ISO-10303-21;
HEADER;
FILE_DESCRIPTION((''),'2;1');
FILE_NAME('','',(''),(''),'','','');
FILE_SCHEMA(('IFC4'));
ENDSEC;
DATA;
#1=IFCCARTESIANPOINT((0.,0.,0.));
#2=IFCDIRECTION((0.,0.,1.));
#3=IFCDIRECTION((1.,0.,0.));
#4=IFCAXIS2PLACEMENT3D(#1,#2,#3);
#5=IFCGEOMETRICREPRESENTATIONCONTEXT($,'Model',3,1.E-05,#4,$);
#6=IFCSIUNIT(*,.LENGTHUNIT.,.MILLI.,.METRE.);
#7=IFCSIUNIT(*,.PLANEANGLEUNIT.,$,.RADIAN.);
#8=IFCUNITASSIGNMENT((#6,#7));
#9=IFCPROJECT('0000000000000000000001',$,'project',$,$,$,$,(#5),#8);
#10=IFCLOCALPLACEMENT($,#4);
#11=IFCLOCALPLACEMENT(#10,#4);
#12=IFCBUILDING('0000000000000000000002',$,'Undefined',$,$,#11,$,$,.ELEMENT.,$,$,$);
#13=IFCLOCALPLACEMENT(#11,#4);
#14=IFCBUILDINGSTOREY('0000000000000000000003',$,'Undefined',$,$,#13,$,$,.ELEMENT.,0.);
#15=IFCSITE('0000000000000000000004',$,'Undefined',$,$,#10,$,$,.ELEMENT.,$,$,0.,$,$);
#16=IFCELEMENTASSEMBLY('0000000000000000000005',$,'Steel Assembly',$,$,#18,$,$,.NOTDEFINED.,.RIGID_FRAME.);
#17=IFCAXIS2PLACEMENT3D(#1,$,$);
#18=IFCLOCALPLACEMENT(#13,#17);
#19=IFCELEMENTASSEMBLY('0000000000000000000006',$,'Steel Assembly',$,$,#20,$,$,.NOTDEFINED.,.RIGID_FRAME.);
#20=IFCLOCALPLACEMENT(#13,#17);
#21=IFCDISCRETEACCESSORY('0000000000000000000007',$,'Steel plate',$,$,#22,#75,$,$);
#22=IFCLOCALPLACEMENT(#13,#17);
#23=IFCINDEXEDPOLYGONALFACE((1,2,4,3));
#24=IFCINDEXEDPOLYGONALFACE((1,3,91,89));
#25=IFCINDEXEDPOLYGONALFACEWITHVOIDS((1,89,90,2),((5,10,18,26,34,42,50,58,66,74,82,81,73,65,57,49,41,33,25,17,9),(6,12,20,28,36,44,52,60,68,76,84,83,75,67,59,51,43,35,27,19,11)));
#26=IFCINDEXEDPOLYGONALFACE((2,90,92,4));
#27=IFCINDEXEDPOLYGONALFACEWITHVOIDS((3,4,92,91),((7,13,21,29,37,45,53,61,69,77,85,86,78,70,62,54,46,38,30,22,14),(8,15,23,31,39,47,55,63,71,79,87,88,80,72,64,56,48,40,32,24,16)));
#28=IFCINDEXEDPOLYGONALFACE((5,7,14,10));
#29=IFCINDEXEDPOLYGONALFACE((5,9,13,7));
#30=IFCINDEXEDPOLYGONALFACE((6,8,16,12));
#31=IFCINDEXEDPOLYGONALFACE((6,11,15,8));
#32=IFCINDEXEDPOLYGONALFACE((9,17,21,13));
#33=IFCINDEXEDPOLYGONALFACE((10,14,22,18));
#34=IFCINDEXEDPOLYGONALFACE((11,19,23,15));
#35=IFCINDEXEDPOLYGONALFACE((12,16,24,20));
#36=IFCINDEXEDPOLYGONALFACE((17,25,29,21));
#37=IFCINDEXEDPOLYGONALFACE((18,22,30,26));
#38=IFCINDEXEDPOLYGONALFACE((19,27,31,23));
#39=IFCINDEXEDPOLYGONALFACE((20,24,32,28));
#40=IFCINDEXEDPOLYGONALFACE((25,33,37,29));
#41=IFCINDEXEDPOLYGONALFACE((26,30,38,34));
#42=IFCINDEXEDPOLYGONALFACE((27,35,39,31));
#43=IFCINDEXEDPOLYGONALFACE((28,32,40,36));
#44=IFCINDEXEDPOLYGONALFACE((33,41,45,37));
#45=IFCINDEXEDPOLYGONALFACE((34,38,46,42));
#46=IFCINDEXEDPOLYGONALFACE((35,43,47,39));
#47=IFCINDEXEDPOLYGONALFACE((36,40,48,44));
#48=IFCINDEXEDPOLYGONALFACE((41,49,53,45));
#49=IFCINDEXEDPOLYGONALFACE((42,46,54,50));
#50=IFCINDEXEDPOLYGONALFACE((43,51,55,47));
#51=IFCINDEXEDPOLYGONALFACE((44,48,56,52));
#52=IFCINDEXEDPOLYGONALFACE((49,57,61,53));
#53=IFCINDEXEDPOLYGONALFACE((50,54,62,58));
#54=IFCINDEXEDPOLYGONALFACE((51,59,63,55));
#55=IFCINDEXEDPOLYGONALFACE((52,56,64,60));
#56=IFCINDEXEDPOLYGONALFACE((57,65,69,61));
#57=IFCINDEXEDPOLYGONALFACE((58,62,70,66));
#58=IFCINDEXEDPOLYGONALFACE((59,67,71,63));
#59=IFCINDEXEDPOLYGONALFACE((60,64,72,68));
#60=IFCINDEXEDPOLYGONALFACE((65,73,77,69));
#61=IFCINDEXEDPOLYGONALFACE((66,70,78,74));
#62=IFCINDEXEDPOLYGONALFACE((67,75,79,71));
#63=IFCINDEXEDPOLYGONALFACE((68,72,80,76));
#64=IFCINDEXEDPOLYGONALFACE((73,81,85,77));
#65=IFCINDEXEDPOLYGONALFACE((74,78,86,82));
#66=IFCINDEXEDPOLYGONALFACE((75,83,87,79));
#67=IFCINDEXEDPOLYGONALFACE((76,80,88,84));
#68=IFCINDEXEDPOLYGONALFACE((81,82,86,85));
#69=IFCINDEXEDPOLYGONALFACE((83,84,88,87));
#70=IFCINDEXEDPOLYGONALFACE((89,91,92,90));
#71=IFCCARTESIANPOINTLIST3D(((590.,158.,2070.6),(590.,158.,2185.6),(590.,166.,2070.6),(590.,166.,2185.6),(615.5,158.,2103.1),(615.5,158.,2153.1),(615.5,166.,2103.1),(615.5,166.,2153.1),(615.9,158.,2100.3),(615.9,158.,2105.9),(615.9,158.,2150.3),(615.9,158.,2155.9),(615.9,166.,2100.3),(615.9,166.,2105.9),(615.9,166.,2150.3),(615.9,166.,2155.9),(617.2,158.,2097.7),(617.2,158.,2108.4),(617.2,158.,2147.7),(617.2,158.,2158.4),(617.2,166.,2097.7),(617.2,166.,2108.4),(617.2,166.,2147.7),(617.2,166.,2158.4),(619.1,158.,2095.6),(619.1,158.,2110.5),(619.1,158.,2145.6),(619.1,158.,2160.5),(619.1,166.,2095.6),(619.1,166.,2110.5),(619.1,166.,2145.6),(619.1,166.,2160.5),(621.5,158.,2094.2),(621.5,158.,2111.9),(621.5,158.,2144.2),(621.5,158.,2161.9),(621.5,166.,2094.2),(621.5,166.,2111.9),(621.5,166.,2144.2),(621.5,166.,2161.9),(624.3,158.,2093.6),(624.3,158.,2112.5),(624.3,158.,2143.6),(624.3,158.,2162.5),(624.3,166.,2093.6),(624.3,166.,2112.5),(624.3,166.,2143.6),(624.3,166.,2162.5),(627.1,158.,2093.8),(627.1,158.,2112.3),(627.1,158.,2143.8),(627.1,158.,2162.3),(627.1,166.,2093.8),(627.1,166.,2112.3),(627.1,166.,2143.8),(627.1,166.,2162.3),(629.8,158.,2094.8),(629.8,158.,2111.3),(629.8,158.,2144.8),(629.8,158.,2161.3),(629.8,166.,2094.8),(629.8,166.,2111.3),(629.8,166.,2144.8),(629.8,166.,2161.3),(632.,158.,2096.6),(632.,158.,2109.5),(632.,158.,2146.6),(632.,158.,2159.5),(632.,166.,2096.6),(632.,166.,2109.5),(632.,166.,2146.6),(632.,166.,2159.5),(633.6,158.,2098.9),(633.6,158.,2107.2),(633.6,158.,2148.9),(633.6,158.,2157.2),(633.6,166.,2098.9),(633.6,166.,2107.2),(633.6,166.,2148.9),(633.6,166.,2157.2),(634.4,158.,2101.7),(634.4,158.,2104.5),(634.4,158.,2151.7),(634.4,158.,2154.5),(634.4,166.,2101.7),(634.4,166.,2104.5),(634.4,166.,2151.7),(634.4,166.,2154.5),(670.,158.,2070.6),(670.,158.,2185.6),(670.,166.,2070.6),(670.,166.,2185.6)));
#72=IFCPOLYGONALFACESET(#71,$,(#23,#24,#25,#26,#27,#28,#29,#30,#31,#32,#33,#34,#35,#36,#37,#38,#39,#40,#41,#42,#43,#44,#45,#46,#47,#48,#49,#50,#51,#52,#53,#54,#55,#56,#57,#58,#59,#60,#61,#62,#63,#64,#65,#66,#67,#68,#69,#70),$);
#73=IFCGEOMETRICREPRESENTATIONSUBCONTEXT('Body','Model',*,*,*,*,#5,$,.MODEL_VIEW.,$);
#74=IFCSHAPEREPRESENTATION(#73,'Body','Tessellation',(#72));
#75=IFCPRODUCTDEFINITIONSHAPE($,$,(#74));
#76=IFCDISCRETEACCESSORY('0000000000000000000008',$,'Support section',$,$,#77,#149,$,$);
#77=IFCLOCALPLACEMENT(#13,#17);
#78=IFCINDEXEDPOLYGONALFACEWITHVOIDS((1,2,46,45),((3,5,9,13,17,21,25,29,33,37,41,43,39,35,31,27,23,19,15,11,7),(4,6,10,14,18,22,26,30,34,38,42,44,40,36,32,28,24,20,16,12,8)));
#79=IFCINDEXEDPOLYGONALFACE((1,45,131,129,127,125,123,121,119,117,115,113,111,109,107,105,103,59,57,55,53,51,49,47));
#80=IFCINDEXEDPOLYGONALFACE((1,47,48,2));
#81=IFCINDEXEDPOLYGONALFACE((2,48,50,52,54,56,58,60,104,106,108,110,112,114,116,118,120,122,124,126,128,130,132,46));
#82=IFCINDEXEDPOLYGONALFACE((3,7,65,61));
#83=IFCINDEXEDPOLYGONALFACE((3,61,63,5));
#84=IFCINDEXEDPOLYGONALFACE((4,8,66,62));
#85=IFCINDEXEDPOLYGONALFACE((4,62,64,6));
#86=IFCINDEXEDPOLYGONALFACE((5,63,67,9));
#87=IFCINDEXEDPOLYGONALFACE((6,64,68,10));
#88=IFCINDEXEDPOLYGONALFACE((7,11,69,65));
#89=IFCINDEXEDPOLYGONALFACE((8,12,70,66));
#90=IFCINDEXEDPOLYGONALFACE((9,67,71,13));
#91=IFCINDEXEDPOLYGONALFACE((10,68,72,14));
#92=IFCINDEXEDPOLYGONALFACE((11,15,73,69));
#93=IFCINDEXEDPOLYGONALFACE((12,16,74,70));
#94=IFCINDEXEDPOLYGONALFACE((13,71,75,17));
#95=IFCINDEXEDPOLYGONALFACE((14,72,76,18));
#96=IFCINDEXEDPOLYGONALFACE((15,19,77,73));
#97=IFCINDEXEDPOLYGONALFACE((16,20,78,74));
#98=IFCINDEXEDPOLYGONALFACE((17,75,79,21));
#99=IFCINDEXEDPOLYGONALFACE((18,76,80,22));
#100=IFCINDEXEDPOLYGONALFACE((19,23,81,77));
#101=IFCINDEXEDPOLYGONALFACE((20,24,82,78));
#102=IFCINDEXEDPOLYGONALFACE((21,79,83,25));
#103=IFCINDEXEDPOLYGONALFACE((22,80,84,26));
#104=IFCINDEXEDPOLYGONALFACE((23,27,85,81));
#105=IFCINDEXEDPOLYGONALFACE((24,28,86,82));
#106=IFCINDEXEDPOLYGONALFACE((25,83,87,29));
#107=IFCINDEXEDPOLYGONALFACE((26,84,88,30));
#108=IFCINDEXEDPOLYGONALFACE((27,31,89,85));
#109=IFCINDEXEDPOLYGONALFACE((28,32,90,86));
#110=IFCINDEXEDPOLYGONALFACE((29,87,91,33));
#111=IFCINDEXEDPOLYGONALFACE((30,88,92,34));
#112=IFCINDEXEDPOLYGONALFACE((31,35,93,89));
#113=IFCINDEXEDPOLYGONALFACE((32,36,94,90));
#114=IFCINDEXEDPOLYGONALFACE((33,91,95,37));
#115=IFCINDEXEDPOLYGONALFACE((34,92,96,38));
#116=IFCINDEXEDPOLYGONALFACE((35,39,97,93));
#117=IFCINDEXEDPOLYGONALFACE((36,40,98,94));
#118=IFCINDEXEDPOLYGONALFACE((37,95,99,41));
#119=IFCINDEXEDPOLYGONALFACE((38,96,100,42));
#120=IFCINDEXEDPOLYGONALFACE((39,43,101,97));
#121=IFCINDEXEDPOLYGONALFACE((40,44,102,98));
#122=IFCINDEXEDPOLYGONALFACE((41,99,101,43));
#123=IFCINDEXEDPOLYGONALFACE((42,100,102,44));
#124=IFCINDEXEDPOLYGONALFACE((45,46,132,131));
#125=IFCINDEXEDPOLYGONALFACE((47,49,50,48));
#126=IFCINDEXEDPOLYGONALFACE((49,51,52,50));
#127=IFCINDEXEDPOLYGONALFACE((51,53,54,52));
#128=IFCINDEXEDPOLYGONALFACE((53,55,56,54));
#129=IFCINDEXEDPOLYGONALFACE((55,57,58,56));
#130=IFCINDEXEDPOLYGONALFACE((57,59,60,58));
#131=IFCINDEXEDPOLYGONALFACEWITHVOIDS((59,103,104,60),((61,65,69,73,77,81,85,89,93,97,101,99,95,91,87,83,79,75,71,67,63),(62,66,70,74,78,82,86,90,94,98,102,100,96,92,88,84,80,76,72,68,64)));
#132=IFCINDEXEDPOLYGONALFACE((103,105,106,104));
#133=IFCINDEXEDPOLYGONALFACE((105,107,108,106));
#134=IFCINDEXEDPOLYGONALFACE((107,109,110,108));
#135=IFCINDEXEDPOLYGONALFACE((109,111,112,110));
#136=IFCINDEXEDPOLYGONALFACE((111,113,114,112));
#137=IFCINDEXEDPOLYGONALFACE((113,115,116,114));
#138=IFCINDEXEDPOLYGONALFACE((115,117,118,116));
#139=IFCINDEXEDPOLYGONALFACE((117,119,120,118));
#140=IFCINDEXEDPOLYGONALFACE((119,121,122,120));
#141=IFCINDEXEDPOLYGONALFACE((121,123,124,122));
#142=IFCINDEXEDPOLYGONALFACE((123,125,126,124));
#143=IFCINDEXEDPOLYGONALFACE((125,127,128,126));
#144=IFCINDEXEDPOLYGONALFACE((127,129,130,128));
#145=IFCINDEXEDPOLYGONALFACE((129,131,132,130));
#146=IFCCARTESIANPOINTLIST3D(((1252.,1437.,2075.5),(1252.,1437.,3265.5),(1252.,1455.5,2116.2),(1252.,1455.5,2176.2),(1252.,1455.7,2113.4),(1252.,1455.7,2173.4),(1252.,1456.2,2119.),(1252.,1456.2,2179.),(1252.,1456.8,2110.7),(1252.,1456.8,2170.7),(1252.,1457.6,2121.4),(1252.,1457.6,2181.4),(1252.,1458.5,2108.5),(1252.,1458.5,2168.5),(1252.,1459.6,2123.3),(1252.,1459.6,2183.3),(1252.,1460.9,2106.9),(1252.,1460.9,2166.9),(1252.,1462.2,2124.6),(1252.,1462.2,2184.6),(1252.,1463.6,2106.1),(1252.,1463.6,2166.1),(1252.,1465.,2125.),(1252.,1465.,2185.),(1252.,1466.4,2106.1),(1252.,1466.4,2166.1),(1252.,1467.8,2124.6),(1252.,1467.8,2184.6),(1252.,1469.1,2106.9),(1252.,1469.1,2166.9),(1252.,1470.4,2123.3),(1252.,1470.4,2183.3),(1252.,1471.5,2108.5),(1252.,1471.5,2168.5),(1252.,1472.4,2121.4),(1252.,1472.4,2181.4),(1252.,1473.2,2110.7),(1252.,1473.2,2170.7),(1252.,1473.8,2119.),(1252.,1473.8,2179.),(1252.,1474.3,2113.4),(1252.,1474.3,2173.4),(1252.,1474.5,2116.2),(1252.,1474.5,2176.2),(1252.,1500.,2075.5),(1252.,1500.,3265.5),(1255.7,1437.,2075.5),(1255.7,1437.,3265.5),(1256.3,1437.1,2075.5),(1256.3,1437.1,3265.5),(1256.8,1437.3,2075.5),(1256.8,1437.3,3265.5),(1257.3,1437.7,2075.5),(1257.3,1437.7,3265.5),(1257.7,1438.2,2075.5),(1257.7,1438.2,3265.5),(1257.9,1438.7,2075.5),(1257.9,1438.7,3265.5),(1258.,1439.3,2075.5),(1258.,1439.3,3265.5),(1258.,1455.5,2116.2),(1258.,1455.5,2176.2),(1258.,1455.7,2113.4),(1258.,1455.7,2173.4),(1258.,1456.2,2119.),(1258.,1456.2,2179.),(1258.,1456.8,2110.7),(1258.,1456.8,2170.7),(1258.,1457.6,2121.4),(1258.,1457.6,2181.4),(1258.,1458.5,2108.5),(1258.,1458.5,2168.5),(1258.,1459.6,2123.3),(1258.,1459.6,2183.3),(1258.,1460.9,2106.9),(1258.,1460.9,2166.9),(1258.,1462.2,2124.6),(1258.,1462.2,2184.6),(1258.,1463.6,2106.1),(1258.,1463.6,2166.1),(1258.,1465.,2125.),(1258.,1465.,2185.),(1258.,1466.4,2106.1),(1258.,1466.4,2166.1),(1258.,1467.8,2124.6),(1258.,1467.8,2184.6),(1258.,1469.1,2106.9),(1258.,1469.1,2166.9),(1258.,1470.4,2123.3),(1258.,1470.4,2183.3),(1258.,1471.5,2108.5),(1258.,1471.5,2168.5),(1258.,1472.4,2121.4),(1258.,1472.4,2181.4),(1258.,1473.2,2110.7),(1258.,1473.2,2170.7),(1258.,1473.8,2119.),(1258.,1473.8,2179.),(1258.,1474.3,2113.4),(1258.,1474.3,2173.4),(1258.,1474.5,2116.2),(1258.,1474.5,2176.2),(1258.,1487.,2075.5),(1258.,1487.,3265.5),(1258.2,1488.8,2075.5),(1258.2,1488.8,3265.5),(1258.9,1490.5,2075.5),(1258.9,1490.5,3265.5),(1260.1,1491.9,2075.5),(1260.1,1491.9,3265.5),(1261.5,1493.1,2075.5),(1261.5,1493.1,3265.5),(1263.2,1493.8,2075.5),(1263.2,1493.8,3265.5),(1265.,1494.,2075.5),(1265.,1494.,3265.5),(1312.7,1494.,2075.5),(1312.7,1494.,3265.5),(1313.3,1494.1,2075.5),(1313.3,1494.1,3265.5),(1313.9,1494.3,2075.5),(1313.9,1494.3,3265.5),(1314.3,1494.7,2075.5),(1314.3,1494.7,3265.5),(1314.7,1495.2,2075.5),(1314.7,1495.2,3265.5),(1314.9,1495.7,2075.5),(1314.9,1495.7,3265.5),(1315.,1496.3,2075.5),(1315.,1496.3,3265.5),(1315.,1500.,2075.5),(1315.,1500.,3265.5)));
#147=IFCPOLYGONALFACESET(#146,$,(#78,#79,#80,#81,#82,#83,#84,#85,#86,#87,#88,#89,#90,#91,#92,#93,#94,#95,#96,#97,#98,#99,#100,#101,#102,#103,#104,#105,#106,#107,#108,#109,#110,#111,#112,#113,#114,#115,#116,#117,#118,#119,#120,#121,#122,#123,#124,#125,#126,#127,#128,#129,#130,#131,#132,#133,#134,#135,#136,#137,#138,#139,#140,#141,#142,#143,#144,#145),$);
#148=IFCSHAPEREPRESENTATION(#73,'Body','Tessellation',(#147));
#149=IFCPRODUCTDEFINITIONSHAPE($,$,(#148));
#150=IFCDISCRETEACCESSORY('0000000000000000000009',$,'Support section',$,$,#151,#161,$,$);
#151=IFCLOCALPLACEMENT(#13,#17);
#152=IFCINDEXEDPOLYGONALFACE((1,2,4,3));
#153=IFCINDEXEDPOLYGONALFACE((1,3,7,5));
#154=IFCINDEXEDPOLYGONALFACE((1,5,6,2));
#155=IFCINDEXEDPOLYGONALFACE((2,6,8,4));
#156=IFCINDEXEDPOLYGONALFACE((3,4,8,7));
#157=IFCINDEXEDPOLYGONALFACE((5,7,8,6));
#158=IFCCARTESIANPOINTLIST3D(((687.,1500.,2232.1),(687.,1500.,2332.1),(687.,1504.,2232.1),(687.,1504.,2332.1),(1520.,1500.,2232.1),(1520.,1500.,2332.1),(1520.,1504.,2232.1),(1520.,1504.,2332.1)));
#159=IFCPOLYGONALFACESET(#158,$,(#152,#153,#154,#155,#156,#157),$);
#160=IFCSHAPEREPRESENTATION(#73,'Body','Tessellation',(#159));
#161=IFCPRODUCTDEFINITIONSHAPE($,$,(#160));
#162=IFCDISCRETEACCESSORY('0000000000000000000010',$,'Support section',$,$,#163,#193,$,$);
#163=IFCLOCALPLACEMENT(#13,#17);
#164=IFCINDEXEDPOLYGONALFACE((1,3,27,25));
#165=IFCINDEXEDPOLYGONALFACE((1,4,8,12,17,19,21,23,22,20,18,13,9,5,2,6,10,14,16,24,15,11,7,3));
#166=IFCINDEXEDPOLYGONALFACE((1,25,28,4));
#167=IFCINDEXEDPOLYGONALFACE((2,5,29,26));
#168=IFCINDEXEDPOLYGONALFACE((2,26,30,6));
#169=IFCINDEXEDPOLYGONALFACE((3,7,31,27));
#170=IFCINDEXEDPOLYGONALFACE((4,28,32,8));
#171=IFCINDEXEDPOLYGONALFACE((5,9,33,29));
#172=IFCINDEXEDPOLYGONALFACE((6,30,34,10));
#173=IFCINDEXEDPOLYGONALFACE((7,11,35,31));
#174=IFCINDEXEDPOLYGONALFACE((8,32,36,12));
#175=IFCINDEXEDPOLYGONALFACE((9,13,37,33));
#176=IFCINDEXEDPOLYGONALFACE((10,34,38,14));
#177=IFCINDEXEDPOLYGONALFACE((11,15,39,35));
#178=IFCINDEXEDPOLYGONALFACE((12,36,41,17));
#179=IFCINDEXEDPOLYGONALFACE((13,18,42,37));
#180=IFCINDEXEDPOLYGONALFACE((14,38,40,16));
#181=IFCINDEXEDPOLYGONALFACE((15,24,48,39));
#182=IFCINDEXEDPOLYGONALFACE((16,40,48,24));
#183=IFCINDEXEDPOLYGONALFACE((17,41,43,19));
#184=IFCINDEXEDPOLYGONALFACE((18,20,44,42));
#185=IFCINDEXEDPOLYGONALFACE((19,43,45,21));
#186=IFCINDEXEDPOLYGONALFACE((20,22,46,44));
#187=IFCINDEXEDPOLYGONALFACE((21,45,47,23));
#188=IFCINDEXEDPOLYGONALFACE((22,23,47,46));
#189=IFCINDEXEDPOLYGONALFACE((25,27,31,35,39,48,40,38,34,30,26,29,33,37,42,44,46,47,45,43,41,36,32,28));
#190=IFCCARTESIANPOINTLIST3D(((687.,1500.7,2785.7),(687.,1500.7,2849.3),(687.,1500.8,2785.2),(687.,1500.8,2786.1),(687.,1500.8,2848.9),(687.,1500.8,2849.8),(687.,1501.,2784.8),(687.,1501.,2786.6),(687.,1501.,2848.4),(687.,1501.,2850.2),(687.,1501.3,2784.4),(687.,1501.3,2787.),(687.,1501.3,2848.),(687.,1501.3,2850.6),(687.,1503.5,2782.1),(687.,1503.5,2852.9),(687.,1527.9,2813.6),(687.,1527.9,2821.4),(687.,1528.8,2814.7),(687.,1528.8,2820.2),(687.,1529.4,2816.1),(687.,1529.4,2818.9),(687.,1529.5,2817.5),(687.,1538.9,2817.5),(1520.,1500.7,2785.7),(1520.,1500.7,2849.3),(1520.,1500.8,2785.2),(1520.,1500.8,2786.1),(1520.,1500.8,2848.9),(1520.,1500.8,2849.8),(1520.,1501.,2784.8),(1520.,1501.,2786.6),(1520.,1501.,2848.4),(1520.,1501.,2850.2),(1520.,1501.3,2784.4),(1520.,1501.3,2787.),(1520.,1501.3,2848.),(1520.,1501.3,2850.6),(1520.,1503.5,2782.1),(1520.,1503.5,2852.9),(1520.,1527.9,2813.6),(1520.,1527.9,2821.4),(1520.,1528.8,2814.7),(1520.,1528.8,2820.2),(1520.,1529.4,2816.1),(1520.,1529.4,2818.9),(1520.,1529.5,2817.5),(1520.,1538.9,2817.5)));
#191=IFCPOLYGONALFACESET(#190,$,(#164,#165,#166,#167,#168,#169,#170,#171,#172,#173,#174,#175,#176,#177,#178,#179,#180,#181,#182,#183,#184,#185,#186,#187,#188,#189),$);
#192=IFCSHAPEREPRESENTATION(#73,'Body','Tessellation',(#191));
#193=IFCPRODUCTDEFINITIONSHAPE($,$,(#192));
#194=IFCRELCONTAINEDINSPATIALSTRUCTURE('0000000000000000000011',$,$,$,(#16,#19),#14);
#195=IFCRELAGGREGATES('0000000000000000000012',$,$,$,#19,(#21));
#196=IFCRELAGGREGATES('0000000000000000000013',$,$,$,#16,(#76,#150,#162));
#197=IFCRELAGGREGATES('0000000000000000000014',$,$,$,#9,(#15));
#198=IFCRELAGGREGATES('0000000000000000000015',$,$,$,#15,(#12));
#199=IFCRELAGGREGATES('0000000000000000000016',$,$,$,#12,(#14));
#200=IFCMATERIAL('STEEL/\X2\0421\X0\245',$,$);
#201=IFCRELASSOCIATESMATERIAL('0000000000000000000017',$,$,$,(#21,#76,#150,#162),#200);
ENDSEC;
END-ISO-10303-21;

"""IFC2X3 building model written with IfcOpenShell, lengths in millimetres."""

from ifc_helpers import new_model, si_unit, frame, origin_with_axes, origin_2d_with_axis, place, context, subcontext, project, spatial, polyline, rectangle, circle, l_section, outline, extrude, source, transform, mapped, material, element, aggregate, save


model = new_model("IFC2X3")

# Units and contexts
model_context = context("Model", 3, precision=1e-05, world=origin_with_axes())
body_context = subcontext(model_context, "Body", "Model", "MODEL_VIEW")
ifc_project = project(units=[si_unit("LENGTHUNIT", "METRE", prefix="MILLI"), si_unit("PLANEANGLEUNIT", "RADIAN")], contexts=[model_context])

# Site, building, storey
site_placement = place(None, origin_with_axes())
site = spatial("IfcSite", under=ifc_project, at=site_placement, Name="Undefined", CompositionType="ELEMENT", RefElevation=0.0)
building_placement = place(site_placement, origin_with_axes())
building = spatial("IfcBuilding", under=site, at=building_placement, Name="Undefined", CompositionType="ELEMENT")
storey_placement = place(building_placement, origin_with_axes())
storey = spatial("IfcBuildingStorey", under=building, at=storey_placement, Name="Undefined", CompositionType="ELEMENT", Elevation=0.0)

# Element assembly
assembly_1_placement = place(storey_placement, origin_with_axes())
assembly_1 = element("IfcElementAssembly", 1, at=assembly_1_placement, inside=storey, Name="Steel Assembly", AssemblyPlace="NOTDEFINED", PredefinedType="RIGID_FRAME")
ifc_material_1 = material(Name="STEEL/С245")
shared_shape_1 = source(origin_with_axes(), body_context, "Body", "SweptSolid", [
    extrude(circle(Radius=9.5, at=origin_2d_with_axis()), frame((0.0, -0.1, 0.0), z_axis=(0.0, 1.0, 0.0), x_axis=(1.0, 0.0, 0.0)), (0.0, 0.0, 1.0), 6.2),
])

# Element assembly
assembly_2_placement = place(storey_placement, origin_with_axes())
assembly_2 = element("IfcElementAssembly", 2, at=assembly_2_placement, inside=storey, Name="Steel Assembly", AssemblyPlace="NOTDEFINED", PredefinedType="RIGID_FRAME")

# Discrete accessories, openings
discrete_accessory_1_placement = place(assembly_2_placement, frame((670.0, 162.0, 2185.6), z_axis=(0.0, -1.0, 0.0), x_axis=(-1.0, 0.0, 0.0)))
discrete_accessory_1 = element("IfcDiscreteAccessory", 3, at=discrete_accessory_1_placement, material=ifc_material_1, Name="Steel plate", context=body_context, shape_type="SweptSolid", body=[
    extrude(outline(polyline([(0.0, 0.0), (80.0, 0.0), (80.0, 115.0), (0.0, 115.0), (0.0, 0.0)])), frame((0.0, 0.0, -4.0), z_axis=(0.0, 0.0, 1.0), x_axis=(1.0, 0.0, 0.0)), (0.0, 0.0, 1.0), 8.0),
])
shared_shape_2 = source(origin_with_axes(), body_context, "Body", "SweptSolid", [
    extrude(circle(Radius=9.5, at=origin_2d_with_axis()), frame((0.0, 3.9, 0.0), z_axis=(0.0, 1.0, 0.0), x_axis=(1.0, 0.0, 0.0)), (0.0, 0.0, 1.0), 12.1),
])
opening_1_placement = place(assembly_2_placement, frame((625.0, 170.0, 2128.1), z_axis=(0.0, 0.0, 1.0), x_axis=(-1.0, 0.0, 0.0)))
element("IfcOpeningElement", 4, at=opening_1_placement, cuts=discrete_accessory_1, ObjectType="Opening", context=body_context, shape_type="MappedRepresentation", body=[
    mapped(shared_shape_2, transform((0.0, 0.0, -25.0))),
    mapped(shared_shape_2, transform((0.0, 0.0, 25.0))),
])
aggregate(assembly_2, [discrete_accessory_1])
discrete_accessory_2_placement = place(assembly_1_placement, frame((1283.5, 1468.5, 2075.5), z_axis=(0.0, 0.0, 1.0), x_axis=(1.0, 0.0, 0.0)))
discrete_accessory_2 = element("IfcDiscreteAccessory", 5, at=discrete_accessory_2_placement, material=ifc_material_1, Name="Support section", context=body_context, shape_type="SweptSolid", body=[
    extrude(l_section(Depth=63.0, Width=63.0, Thickness=6.0, FilletRadius=7.0, EdgeRadius=2.3, at=origin_2d_with_axis()), frame((0.0, 0.0, 1190.0), z_axis=(0.0, 0.0, -1.0), x_axis=(1.0, 0.0, 0.0)), (0.0, 0.0, 1.0), 1190.0),
])
opening_2_placement = place(assembly_1_placement, frame((1252.0, 1465.0, 2115.5), z_axis=(0.0, 1.0, 0.0), x_axis=(0.0, 0.0, 1.0)))
element("IfcOpeningElement", 6, at=opening_2_placement, cuts=discrete_accessory_2, ObjectType="Opening", context=body_context, shape_type="MappedRepresentation", body=[
    mapped(shared_shape_1, transform((0.0, 0.0, 0.0))),
    mapped(shared_shape_1, transform((60.0, 0.0, 0.0))),
])

# Discrete accessories
discrete_accessory_3_placement = place(assembly_1_placement, frame((687.0, 1502.0, 2282.1), z_axis=(0.0, 0.0, 1.0), x_axis=(1.0, 0.0, 0.0)))
discrete_accessory_3 = element("IfcDiscreteAccessory", 7, at=discrete_accessory_3_placement, material=ifc_material_1, Name="Support section", context=body_context, shape_type="SweptSolid", body=[
    extrude(rectangle(XDim=4.0, YDim=100.0, at=origin_2d_with_axis()), frame((833.0, 0.0, 0.0), z_axis=(-1.0, 0.0, 0.0), x_axis=(0.0, -1.0, 0.0)), (0.0, 0.0, 1.0), 833.0),
])
discrete_accessory_4_placement = place(assembly_1_placement, frame((1520.0, 1503.5, 2817.5), z_axis=(0.0, -0.707107, -0.707107), x_axis=(-1.0, 0.0, 0.0)))
discrete_accessory_4 = element("IfcDiscreteAccessory", 8, at=discrete_accessory_4_placement, material=ifc_material_1, Name="Support section", context=body_context, shape_type="SweptSolid", body=[
    extrude(l_section(Depth=50.0, Width=50.0, Thickness=5.0, FilletRadius=5.5, EdgeRadius=1.8, at=origin_2d_with_axis()), frame((833.0, 0.0, 0.0), z_axis=(-1.0, 0.0, 0.0), x_axis=(0.0, -1.0, 0.0)), (0.0, 0.0, 1.0), 833.0),
])
aggregate(assembly_1, [discrete_accessory_2, discrete_accessory_3, discrete_accessory_4])

save(model, "model.ifc")
